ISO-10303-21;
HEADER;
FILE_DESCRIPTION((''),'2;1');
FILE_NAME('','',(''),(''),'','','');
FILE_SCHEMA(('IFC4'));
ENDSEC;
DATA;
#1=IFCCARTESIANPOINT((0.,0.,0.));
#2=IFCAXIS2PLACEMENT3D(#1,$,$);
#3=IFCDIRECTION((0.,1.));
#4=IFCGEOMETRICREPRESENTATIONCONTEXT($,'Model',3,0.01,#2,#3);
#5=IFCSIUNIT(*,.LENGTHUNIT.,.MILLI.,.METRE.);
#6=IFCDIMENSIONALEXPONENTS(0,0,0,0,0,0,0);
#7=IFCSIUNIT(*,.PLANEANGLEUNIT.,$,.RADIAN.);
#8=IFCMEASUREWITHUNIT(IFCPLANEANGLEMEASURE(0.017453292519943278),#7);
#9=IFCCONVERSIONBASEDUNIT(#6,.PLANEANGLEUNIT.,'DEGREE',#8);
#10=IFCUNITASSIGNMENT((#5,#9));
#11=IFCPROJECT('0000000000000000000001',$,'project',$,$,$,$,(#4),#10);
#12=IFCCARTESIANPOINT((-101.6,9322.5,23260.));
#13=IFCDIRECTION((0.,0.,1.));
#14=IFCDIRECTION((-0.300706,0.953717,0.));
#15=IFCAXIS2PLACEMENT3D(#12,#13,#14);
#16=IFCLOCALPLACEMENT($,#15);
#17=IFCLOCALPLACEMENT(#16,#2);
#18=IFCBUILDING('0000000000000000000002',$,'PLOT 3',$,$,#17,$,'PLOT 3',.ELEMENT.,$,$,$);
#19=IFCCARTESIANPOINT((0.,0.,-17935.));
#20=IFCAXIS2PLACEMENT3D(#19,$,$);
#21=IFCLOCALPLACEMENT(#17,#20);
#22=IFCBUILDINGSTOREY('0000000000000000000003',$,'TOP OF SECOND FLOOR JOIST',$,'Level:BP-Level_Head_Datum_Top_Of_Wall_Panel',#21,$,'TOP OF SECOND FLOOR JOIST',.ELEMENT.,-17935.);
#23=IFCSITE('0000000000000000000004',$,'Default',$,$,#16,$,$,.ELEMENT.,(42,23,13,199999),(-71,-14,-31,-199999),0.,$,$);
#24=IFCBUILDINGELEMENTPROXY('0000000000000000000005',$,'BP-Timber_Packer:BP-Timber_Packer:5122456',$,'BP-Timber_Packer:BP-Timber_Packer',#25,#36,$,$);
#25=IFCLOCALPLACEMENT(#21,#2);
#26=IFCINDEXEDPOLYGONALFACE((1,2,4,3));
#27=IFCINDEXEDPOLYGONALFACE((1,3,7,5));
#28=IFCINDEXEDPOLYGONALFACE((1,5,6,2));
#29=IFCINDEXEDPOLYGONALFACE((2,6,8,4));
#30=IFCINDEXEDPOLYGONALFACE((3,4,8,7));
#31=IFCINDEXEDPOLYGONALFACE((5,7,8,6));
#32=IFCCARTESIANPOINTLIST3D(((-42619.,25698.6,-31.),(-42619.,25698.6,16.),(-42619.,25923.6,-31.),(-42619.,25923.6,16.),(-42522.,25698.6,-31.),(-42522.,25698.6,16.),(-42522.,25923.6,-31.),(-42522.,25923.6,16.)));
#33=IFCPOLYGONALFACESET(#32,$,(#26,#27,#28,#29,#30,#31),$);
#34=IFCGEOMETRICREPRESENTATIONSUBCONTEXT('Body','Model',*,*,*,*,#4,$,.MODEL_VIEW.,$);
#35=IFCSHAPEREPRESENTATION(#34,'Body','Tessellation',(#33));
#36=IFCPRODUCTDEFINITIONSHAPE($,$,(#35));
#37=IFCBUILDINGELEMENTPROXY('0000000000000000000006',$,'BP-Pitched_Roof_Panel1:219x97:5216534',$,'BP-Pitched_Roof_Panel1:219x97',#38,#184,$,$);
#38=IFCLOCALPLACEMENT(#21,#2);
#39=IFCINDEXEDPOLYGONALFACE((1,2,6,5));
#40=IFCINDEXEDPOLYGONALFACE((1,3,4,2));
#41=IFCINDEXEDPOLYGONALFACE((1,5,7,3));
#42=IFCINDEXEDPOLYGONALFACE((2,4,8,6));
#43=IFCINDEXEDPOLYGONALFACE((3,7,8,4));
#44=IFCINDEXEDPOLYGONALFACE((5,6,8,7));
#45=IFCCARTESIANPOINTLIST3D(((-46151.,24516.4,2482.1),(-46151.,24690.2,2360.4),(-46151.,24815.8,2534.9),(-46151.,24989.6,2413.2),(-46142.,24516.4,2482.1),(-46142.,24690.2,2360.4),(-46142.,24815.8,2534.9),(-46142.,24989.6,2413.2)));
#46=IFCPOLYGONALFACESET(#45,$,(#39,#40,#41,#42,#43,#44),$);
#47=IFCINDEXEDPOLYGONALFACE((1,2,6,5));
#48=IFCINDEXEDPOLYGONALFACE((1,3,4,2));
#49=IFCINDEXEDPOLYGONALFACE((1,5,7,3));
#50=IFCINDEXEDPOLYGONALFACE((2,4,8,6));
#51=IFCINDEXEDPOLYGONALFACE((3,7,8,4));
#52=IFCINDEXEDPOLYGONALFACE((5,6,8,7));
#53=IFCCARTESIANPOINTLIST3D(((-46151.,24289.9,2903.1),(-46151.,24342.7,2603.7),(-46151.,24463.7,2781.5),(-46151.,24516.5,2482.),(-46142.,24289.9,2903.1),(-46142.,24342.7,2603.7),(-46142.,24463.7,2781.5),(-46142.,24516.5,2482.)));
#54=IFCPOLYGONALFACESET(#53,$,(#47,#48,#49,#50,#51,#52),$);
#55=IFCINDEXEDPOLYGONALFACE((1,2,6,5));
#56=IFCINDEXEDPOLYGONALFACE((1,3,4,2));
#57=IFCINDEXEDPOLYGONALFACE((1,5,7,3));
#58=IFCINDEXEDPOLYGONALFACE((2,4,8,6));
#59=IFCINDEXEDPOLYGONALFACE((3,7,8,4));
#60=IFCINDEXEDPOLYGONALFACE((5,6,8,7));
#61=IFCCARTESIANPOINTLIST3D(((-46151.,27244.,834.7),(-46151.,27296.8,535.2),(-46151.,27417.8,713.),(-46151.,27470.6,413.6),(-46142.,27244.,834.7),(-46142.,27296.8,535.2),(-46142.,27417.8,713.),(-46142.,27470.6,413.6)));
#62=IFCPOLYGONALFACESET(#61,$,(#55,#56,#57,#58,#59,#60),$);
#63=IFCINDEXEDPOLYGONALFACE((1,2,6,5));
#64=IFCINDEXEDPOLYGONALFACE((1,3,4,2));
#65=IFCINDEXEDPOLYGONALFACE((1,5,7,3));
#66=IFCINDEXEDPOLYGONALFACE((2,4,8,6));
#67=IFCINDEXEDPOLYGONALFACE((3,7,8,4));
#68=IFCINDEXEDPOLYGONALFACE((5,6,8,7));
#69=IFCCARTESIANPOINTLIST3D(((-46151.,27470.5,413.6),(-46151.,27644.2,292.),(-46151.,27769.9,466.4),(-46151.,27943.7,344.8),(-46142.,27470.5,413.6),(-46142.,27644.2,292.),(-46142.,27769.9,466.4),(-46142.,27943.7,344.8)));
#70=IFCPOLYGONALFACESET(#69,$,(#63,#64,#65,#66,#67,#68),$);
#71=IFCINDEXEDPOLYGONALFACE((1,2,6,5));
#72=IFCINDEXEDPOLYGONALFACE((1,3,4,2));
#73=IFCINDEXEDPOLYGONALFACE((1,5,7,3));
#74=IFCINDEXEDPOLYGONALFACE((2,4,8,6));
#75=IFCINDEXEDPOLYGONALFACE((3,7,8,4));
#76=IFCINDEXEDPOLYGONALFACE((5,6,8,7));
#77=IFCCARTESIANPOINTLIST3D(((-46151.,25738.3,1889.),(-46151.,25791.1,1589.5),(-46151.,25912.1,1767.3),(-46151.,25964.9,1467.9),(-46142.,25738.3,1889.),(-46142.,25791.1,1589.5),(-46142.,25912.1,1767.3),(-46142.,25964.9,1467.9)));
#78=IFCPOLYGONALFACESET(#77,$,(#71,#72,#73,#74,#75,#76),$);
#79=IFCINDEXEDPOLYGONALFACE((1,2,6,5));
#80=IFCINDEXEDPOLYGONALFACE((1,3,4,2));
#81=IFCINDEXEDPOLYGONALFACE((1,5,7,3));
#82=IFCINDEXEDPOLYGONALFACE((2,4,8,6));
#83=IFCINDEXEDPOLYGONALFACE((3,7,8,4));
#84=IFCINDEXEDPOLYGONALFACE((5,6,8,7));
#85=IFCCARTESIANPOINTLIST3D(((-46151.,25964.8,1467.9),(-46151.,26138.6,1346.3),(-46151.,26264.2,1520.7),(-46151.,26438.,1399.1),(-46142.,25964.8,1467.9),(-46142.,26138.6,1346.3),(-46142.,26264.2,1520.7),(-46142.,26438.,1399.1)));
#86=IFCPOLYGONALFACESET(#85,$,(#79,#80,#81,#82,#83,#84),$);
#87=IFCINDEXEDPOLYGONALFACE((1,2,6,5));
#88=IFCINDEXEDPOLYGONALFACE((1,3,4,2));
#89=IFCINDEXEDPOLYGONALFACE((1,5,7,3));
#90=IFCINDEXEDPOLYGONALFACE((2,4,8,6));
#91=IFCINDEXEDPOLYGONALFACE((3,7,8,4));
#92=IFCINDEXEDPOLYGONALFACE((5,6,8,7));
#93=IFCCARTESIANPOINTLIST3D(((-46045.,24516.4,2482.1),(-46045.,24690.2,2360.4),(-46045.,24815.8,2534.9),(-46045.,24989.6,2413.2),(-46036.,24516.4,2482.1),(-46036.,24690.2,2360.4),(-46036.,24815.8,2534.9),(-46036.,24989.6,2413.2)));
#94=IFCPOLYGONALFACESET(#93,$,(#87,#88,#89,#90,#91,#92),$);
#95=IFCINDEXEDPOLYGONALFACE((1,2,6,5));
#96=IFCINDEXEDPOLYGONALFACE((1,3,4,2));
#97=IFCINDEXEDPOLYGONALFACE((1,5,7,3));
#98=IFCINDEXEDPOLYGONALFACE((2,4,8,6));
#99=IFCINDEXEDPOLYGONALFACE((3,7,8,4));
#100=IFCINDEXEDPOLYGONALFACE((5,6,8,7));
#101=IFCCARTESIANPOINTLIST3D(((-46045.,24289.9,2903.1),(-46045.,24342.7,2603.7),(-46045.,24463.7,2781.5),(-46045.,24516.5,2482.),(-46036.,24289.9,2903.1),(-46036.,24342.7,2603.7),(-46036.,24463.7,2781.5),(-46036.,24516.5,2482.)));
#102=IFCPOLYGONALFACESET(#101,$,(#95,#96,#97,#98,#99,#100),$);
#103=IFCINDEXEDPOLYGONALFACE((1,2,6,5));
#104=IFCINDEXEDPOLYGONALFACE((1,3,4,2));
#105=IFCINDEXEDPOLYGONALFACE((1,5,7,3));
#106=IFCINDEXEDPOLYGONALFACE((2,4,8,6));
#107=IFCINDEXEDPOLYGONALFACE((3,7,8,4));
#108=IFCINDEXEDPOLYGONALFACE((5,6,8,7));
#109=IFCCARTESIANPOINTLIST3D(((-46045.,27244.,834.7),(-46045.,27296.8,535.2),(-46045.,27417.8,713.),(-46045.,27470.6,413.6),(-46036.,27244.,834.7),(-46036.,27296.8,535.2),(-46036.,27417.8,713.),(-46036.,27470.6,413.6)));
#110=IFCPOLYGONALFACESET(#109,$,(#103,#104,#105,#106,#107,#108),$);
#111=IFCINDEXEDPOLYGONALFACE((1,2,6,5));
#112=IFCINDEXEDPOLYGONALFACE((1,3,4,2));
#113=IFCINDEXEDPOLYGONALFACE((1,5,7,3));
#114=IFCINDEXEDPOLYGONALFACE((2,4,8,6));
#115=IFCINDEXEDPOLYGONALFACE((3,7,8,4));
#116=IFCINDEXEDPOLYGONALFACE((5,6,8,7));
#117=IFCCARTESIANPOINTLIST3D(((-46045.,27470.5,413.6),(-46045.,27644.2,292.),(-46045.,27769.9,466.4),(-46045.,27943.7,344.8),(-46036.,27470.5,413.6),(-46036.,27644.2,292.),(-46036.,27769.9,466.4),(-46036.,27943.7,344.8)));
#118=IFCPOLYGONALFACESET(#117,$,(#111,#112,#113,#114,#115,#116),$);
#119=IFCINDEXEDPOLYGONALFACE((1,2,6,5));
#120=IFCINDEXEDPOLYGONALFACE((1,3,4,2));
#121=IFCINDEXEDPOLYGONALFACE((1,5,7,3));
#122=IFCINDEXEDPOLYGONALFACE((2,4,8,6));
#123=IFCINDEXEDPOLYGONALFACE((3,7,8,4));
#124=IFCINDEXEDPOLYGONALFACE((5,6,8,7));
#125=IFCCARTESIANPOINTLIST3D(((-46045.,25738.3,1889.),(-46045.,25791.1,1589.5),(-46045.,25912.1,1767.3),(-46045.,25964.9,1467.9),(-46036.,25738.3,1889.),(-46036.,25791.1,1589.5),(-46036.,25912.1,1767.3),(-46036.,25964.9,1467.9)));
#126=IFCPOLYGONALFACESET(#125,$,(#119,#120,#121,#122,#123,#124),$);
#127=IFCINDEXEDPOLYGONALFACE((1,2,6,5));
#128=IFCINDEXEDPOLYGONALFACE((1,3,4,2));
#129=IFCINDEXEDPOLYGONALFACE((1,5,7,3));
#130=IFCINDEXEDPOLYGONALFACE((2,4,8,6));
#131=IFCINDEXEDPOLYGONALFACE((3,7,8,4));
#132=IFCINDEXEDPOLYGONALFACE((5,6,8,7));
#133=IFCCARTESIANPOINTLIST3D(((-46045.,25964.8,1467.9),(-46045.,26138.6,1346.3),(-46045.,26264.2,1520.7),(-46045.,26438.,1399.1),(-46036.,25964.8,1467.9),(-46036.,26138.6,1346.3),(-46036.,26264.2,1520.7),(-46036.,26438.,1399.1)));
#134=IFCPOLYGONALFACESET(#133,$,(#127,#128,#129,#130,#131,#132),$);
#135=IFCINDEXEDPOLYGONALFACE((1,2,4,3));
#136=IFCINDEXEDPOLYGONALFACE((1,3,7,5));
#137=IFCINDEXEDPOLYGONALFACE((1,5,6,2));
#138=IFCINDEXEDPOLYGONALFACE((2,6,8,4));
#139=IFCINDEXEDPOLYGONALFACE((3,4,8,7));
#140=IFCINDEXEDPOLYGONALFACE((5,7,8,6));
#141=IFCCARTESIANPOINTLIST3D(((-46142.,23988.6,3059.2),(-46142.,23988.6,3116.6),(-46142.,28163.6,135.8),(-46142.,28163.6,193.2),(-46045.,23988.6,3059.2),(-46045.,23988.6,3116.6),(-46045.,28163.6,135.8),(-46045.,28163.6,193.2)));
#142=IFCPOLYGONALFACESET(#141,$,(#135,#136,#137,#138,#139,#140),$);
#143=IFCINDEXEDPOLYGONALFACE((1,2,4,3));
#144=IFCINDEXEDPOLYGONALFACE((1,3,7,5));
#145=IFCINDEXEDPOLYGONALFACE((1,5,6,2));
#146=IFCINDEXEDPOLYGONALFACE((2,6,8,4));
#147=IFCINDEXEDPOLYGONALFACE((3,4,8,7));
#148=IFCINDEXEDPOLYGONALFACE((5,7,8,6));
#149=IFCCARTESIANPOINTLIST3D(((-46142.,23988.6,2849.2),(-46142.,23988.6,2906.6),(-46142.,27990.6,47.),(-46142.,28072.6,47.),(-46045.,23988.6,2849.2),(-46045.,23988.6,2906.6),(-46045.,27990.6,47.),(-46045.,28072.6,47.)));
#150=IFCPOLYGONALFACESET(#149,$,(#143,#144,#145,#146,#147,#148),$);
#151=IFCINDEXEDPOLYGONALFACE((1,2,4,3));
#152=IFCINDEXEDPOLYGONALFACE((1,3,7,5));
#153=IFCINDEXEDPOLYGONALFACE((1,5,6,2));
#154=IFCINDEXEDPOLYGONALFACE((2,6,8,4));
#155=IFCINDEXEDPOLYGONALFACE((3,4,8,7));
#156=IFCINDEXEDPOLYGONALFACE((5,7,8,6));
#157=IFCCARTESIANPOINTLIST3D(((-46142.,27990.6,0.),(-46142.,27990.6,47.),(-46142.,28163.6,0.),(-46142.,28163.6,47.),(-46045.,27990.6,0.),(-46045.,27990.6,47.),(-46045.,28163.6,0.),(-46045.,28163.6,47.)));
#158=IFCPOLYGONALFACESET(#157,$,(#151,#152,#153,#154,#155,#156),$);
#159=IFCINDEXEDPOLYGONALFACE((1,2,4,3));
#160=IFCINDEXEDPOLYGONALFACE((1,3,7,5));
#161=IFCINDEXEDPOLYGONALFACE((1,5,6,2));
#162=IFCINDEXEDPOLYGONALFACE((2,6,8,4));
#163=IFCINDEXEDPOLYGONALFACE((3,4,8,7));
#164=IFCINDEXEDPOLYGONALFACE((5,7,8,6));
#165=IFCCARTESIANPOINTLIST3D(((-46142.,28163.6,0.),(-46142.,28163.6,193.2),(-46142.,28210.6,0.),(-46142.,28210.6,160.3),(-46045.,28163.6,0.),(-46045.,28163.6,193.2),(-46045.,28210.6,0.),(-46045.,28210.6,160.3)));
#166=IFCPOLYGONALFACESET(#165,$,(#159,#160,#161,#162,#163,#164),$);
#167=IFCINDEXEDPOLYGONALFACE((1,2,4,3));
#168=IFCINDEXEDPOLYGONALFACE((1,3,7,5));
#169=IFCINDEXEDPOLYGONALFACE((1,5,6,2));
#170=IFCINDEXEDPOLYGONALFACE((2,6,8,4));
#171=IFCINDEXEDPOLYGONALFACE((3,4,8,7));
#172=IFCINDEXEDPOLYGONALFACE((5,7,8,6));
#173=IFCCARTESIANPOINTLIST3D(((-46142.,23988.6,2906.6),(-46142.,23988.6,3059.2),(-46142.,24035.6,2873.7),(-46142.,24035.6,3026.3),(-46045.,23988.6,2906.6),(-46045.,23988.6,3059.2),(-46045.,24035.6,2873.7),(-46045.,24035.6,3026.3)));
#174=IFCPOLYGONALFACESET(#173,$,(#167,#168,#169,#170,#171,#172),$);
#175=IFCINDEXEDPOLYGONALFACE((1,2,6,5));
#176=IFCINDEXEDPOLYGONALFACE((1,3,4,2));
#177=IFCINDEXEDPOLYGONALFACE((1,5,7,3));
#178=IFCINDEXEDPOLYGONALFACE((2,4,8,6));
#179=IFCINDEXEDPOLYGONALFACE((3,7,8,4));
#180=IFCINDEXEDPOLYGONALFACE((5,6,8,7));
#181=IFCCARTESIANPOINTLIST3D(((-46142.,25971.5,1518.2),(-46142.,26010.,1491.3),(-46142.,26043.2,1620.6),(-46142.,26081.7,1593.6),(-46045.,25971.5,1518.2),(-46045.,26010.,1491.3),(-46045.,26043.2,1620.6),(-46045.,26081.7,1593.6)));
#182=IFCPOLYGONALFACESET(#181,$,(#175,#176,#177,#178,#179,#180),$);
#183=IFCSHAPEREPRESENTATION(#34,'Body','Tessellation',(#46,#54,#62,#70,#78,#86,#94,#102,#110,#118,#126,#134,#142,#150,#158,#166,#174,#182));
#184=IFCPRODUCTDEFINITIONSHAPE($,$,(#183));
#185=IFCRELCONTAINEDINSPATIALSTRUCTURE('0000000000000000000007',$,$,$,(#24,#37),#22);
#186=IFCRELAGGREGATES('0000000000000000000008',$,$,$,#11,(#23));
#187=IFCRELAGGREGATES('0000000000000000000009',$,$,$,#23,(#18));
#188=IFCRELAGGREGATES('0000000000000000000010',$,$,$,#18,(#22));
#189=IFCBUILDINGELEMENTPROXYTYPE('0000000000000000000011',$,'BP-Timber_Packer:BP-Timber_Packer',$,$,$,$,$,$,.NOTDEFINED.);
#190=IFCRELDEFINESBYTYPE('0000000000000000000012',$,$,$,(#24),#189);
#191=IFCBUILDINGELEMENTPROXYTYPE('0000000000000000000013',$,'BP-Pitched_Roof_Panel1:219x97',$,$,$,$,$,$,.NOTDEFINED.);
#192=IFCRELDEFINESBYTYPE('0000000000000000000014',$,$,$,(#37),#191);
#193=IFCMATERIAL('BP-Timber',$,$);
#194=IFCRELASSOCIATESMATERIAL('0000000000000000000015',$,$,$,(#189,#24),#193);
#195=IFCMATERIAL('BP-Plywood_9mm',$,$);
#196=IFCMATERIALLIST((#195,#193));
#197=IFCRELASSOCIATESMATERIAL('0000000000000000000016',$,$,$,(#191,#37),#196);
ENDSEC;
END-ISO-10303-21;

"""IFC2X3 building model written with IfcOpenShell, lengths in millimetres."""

from ifc_helpers import new_model, entity, si_unit, converted_unit, direction, frame, frame_2d, origin, origin_2d_with_axis, place, context, subcontext, project, spatial, polyline, rectangle, outline, extrude, source, transform, mapped, material, material_list, type_object, type_shapes, element, save


model = new_model("IFC2X3")

# Units and contexts
model_context = context("Model", 3, precision=0.01, world=origin(), true_north=direction((0.0, 1.0)))
body_context = subcontext(model_context, "Body", "Model", "MODEL_VIEW")
ifc_project = project(units=[si_unit("LENGTHUNIT", "METRE", prefix="MILLI"), converted_unit("PLANEANGLEUNIT", "DEGREE", entity("IfcPlaneAngleMeasure", 0.017453292519943278), si_unit("PLANEANGLEUNIT", "RADIAN"), dimensions=[0, 0, 0, 0, 0, 0, 0])], contexts=[model_context])

# Site, building, storey
site_placement = place(None, frame((-101.6, 9322.5, 23260.0), z_axis=(0.0, 0.0, 1.0), x_axis=(-0.300706, 0.953717, 0.0)))
site = spatial("IfcSite", under=ifc_project, at=site_placement, Name="Default", CompositionType="ELEMENT", RefLatitude=(42, 23, 13, 199999), RefLongitude=(-71, -14, -31, -199999), RefElevation=0.0)
building_placement = place(site_placement, origin())
building = spatial("IfcBuilding", under=site, at=building_placement, Name="PLOT 3", LongName="PLOT 3", CompositionType="ELEMENT")
storey_placement = place(building_placement, frame((0.0, 0.0, -17935.0)))
storey = spatial("IfcBuildingStorey", under=building, at=storey_placement, Name="TOP OF SECOND FLOOR JOIST", ObjectType="Level:BP-Level_Head_Datum_Top_Of_Wall_Panel", LongName="TOP OF SECOND FLOOR JOIST", CompositionType="ELEMENT", Elevation=-17935.0)

# Building element proxies
ifc_material_1 = material(Name="BP-Timber")
building_element_proxy_type_1 = type_object("IfcBuildingElementProxyType", Name="BP-Timber_Packer:BP-Timber_Packer", PredefinedType="NOTDEFINED", material=ifc_material_1)
shared_shape_1 = source(origin(), body_context, "Body", "SweptSolid", [
    extrude(rectangle(XDim=225.0, YDim=97.0, at=origin_2d_with_axis()), frame((0.0, 0.0, 0.0), z_axis=(0.0, 0.0, 1.0), x_axis=(-1.0, 0.0, 0.0)), (0.0, 0.0, 1.0), 47.0),
])
type_shapes(building_element_proxy_type_1, [shared_shape_1])
proxy_placement = place(storey_placement, frame((-42570.5, 25811.1, -31.0), z_axis=(0.0, 0.0, 1.0), x_axis=(0.0, 1.0, 0.0)))
element("IfcBuildingElementProxy", 1, at=proxy_placement, inside=storey, type_object=building_element_proxy_type_1, material=ifc_material_1, Name="BP-Timber_Packer:BP-Timber_Packer:5122456", ObjectType="BP-Timber_Packer:BP-Timber_Packer", context=body_context, shape_type="MappedRepresentation", body=[
    mapped(shared_shape_1, transform((0.0, 0.0, 0.0), scale=1.0)),
])
ifc_material_2 = material(Name="BP-Plywood_9mm")
ifc_material_list = material_list([ifc_material_2, ifc_material_1])
building_element_proxy_type_2 = type_object("IfcBuildingElementProxyType", Name="BP-Pitched_Roof_Panel1:219x97", PredefinedType="NOTDEFINED", material=ifc_material_list)
shared_shape_2 = source(origin(), body_context, "Body", "SweptSolid", [
    extrude(outline(polyline([(-77.0, -75.0), (227.0, -75.0), (77.0, 75.0), (-227.0, 75.0), (-77.0, -75.0)])), frame((35.3, -3956.0, 2447.7), z_axis=(0.0, 1.0, 0.0), x_axis=(-0.984808, 0.0, 0.173648)), (0.0, 0.0, 1.0), 9.0),
    extrude(outline(polyline([(1.4, -107.5), (213.6, -107.5), (-1.4, 107.5), (-213.6, 107.5), (1.4, -107.5)])), frame((385.1, -3956.0, 2692.6), z_axis=(0.0, 1.0, 0.0), x_axis=(-0.819152, 0.0, -0.573576)), (0.0, 0.0, 1.0), 9.0),
    extrude(outline(polyline([(1.4, -107.5), (213.6, -107.5), (-1.4, 107.5), (-213.6, 107.5), (1.4, -107.5)])), frame((-2569.0, -3956.0, 624.1), z_axis=(0.0, 1.0, 0.0), x_axis=(-0.819152, 0.0, -0.573576)), (0.0, 0.0, 1.0), 9.0),
    extrude(outline(polyline([(-77.0, -75.0), (227.0, -75.0), (77.0, 75.0), (-227.0, 75.0), (-77.0, -75.0)])), frame((-2918.8, -3956.0, 379.2), z_axis=(0.0, 1.0, 0.0), x_axis=(-0.984808, 0.0, 0.173648)), (0.0, 0.0, 1.0), 9.0),
    extrude(outline(polyline([(1.4, -107.5), (213.6, -107.5), (-1.4, 107.5), (-213.6, 107.5), (1.4, -107.5)])), frame((-1063.3, -3956.0, 1678.4), z_axis=(0.0, 1.0, 0.0), x_axis=(-0.819152, 0.0, -0.573576)), (0.0, 0.0, 1.0), 9.0),
    extrude(outline(polyline([(-77.0, -75.0), (227.0, -75.0), (77.0, 75.0), (-227.0, 75.0), (-77.0, -75.0)])), frame((-1413.1, -3956.0, 1433.5), z_axis=(0.0, 1.0, 0.0), x_axis=(-0.984808, 0.0, 0.173648)), (0.0, 0.0, 1.0), 9.0),
    extrude(outline(polyline([(-77.0, -75.0), (227.0, -75.0), (77.0, 75.0), (-227.0, 75.0), (-77.0, -75.0)])), frame((35.3, -3850.0, 2447.7), z_axis=(0.0, 1.0, 0.0), x_axis=(-0.984808, 0.0, 0.173648)), (0.0, 0.0, 1.0), 9.0),
    extrude(outline(polyline([(1.4, -107.5), (213.6, -107.5), (-1.4, 107.5), (-213.6, 107.5), (1.4, -107.5)])), frame((385.1, -3850.0, 2692.6), z_axis=(0.0, 1.0, 0.0), x_axis=(-0.819152, 0.0, -0.573576)), (0.0, 0.0, 1.0), 9.0),
    extrude(outline(polyline([(1.4, -107.5), (213.6, -107.5), (-1.4, 107.5), (-213.6, 107.5), (1.4, -107.5)])), frame((-2569.0, -3850.0, 624.1), z_axis=(0.0, 1.0, 0.0), x_axis=(-0.819152, 0.0, -0.573576)), (0.0, 0.0, 1.0), 9.0),
    extrude(outline(polyline([(-77.0, -75.0), (227.0, -75.0), (77.0, 75.0), (-227.0, 75.0), (-77.0, -75.0)])), frame((-2918.8, -3850.0, 379.2), z_axis=(0.0, 1.0, 0.0), x_axis=(-0.984808, 0.0, 0.173648)), (0.0, 0.0, 1.0), 9.0),
    extrude(outline(polyline([(1.4, -107.5), (213.6, -107.5), (-1.4, 107.5), (-213.6, 107.5), (1.4, -107.5)])), frame((-1063.3, -3850.0, 1678.4), z_axis=(0.0, 1.0, 0.0), x_axis=(-0.819152, 0.0, -0.573576)), (0.0, 0.0, 1.0), 9.0),
    extrude(outline(polyline([(-77.0, -75.0), (227.0, -75.0), (77.0, 75.0), (-227.0, 75.0), (-77.0, -75.0)])), frame((-1413.1, -3850.0, 1433.5), z_axis=(0.0, 1.0, 0.0), x_axis=(-0.984808, 0.0, 0.173648)), (0.0, 0.0, 1.0), 9.0),
    extrude(outline(polyline([(-1490.4, -2087.5), (-1433.0, -2087.5), (1490.4, 2087.5), (1433.0, 2087.5), (-1490.4, -2087.5)])), frame((-1287.8, -3947.0, 1626.2), z_axis=(0.0, 1.0, 0.0), x_axis=(0.0, 0.0, -1.0)), (0.0, 0.0, 1.0), 97.0),
    extrude(outline(polyline([(-1444.1, -2021.5), (-1386.8, -2021.5), (1415.5, 1980.5), (1415.5, 2062.5), (-1444.1, -2021.5)])), frame((-1221.8, -3947.0, 1462.5), z_axis=(0.0, 1.0, 0.0), x_axis=(0.0, 0.0, -1.0)), (0.0, 0.0, 1.0), 97.0),
    extrude(rectangle(XDim=173.0, YDim=97.0, at=origin_2d_with_axis()), frame((-3288.8, -3898.5, 0.0), z_axis=(0.0, 0.0, 1.0), x_axis=(-1.0, 0.0, 0.0)), (0.0, 0.0, 1.0), 47.0),
    extrude(outline(polyline([(22.0, -72.4), (79.4, -72.4), (-31.4, 85.9), (-69.9, 58.9), (22.0, -72.4)])), frame((-3398.8, -3947.0, 88.4), z_axis=(0.0, 1.0, 0.0), x_axis=(0.819152, 0.0, 0.573576)), (0.0, 0.0, 1.0), 97.0),
    extrude(outline(polyline([(15.1, -62.5), (72.5, -62.5), (-15.1, 62.5), (-72.5, 62.5), (15.1, -62.5)])), frame((776.2, -3947.0, 2966.5), z_axis=(0.0, 1.0, 0.0), x_axis=(0.819152, 0.0, 0.573576)), (0.0, 0.0, 1.0), 97.0),
    extrude(rectangle(XDim=47.0, YDim=97.0, at=frame_2d((0.0, 0.0), x_axis=(1.0, 0.0))), frame((-1202.4, -3898.5, 1504.7), z_axis=(-0.573576, 0.0, 0.819152), x_axis=(-0.819152, 0.0, -0.573576)), (0.0, 0.0, 1.0), 125.0),
])
type_shapes(building_element_proxy_type_2, [shared_shape_2])
for number, where, z_axis, x_axis, name in (
    (2, (-42195.0, 24788.3, 0.0), (0.0, 0.0, 1.0), (0.0, -1.0, 0.0), "BP-Pitched_Roof_Panel1:219x97:5216534"),
):
    element("IfcBuildingElementProxy", number, at=place(storey_placement, frame(where, z_axis=z_axis, x_axis=x_axis)), inside=storey, type_object=building_element_proxy_type_2, material=ifc_material_list, Name=name, ObjectType="BP-Pitched_Roof_Panel1:219x97", context=body_context, shape_type="MappedRepresentation", body=[
        mapped(shared_shape_2, transform((0.0, 0.0, 0.0), scale=1.0)),
    ])

save(model, "model.ifc")
